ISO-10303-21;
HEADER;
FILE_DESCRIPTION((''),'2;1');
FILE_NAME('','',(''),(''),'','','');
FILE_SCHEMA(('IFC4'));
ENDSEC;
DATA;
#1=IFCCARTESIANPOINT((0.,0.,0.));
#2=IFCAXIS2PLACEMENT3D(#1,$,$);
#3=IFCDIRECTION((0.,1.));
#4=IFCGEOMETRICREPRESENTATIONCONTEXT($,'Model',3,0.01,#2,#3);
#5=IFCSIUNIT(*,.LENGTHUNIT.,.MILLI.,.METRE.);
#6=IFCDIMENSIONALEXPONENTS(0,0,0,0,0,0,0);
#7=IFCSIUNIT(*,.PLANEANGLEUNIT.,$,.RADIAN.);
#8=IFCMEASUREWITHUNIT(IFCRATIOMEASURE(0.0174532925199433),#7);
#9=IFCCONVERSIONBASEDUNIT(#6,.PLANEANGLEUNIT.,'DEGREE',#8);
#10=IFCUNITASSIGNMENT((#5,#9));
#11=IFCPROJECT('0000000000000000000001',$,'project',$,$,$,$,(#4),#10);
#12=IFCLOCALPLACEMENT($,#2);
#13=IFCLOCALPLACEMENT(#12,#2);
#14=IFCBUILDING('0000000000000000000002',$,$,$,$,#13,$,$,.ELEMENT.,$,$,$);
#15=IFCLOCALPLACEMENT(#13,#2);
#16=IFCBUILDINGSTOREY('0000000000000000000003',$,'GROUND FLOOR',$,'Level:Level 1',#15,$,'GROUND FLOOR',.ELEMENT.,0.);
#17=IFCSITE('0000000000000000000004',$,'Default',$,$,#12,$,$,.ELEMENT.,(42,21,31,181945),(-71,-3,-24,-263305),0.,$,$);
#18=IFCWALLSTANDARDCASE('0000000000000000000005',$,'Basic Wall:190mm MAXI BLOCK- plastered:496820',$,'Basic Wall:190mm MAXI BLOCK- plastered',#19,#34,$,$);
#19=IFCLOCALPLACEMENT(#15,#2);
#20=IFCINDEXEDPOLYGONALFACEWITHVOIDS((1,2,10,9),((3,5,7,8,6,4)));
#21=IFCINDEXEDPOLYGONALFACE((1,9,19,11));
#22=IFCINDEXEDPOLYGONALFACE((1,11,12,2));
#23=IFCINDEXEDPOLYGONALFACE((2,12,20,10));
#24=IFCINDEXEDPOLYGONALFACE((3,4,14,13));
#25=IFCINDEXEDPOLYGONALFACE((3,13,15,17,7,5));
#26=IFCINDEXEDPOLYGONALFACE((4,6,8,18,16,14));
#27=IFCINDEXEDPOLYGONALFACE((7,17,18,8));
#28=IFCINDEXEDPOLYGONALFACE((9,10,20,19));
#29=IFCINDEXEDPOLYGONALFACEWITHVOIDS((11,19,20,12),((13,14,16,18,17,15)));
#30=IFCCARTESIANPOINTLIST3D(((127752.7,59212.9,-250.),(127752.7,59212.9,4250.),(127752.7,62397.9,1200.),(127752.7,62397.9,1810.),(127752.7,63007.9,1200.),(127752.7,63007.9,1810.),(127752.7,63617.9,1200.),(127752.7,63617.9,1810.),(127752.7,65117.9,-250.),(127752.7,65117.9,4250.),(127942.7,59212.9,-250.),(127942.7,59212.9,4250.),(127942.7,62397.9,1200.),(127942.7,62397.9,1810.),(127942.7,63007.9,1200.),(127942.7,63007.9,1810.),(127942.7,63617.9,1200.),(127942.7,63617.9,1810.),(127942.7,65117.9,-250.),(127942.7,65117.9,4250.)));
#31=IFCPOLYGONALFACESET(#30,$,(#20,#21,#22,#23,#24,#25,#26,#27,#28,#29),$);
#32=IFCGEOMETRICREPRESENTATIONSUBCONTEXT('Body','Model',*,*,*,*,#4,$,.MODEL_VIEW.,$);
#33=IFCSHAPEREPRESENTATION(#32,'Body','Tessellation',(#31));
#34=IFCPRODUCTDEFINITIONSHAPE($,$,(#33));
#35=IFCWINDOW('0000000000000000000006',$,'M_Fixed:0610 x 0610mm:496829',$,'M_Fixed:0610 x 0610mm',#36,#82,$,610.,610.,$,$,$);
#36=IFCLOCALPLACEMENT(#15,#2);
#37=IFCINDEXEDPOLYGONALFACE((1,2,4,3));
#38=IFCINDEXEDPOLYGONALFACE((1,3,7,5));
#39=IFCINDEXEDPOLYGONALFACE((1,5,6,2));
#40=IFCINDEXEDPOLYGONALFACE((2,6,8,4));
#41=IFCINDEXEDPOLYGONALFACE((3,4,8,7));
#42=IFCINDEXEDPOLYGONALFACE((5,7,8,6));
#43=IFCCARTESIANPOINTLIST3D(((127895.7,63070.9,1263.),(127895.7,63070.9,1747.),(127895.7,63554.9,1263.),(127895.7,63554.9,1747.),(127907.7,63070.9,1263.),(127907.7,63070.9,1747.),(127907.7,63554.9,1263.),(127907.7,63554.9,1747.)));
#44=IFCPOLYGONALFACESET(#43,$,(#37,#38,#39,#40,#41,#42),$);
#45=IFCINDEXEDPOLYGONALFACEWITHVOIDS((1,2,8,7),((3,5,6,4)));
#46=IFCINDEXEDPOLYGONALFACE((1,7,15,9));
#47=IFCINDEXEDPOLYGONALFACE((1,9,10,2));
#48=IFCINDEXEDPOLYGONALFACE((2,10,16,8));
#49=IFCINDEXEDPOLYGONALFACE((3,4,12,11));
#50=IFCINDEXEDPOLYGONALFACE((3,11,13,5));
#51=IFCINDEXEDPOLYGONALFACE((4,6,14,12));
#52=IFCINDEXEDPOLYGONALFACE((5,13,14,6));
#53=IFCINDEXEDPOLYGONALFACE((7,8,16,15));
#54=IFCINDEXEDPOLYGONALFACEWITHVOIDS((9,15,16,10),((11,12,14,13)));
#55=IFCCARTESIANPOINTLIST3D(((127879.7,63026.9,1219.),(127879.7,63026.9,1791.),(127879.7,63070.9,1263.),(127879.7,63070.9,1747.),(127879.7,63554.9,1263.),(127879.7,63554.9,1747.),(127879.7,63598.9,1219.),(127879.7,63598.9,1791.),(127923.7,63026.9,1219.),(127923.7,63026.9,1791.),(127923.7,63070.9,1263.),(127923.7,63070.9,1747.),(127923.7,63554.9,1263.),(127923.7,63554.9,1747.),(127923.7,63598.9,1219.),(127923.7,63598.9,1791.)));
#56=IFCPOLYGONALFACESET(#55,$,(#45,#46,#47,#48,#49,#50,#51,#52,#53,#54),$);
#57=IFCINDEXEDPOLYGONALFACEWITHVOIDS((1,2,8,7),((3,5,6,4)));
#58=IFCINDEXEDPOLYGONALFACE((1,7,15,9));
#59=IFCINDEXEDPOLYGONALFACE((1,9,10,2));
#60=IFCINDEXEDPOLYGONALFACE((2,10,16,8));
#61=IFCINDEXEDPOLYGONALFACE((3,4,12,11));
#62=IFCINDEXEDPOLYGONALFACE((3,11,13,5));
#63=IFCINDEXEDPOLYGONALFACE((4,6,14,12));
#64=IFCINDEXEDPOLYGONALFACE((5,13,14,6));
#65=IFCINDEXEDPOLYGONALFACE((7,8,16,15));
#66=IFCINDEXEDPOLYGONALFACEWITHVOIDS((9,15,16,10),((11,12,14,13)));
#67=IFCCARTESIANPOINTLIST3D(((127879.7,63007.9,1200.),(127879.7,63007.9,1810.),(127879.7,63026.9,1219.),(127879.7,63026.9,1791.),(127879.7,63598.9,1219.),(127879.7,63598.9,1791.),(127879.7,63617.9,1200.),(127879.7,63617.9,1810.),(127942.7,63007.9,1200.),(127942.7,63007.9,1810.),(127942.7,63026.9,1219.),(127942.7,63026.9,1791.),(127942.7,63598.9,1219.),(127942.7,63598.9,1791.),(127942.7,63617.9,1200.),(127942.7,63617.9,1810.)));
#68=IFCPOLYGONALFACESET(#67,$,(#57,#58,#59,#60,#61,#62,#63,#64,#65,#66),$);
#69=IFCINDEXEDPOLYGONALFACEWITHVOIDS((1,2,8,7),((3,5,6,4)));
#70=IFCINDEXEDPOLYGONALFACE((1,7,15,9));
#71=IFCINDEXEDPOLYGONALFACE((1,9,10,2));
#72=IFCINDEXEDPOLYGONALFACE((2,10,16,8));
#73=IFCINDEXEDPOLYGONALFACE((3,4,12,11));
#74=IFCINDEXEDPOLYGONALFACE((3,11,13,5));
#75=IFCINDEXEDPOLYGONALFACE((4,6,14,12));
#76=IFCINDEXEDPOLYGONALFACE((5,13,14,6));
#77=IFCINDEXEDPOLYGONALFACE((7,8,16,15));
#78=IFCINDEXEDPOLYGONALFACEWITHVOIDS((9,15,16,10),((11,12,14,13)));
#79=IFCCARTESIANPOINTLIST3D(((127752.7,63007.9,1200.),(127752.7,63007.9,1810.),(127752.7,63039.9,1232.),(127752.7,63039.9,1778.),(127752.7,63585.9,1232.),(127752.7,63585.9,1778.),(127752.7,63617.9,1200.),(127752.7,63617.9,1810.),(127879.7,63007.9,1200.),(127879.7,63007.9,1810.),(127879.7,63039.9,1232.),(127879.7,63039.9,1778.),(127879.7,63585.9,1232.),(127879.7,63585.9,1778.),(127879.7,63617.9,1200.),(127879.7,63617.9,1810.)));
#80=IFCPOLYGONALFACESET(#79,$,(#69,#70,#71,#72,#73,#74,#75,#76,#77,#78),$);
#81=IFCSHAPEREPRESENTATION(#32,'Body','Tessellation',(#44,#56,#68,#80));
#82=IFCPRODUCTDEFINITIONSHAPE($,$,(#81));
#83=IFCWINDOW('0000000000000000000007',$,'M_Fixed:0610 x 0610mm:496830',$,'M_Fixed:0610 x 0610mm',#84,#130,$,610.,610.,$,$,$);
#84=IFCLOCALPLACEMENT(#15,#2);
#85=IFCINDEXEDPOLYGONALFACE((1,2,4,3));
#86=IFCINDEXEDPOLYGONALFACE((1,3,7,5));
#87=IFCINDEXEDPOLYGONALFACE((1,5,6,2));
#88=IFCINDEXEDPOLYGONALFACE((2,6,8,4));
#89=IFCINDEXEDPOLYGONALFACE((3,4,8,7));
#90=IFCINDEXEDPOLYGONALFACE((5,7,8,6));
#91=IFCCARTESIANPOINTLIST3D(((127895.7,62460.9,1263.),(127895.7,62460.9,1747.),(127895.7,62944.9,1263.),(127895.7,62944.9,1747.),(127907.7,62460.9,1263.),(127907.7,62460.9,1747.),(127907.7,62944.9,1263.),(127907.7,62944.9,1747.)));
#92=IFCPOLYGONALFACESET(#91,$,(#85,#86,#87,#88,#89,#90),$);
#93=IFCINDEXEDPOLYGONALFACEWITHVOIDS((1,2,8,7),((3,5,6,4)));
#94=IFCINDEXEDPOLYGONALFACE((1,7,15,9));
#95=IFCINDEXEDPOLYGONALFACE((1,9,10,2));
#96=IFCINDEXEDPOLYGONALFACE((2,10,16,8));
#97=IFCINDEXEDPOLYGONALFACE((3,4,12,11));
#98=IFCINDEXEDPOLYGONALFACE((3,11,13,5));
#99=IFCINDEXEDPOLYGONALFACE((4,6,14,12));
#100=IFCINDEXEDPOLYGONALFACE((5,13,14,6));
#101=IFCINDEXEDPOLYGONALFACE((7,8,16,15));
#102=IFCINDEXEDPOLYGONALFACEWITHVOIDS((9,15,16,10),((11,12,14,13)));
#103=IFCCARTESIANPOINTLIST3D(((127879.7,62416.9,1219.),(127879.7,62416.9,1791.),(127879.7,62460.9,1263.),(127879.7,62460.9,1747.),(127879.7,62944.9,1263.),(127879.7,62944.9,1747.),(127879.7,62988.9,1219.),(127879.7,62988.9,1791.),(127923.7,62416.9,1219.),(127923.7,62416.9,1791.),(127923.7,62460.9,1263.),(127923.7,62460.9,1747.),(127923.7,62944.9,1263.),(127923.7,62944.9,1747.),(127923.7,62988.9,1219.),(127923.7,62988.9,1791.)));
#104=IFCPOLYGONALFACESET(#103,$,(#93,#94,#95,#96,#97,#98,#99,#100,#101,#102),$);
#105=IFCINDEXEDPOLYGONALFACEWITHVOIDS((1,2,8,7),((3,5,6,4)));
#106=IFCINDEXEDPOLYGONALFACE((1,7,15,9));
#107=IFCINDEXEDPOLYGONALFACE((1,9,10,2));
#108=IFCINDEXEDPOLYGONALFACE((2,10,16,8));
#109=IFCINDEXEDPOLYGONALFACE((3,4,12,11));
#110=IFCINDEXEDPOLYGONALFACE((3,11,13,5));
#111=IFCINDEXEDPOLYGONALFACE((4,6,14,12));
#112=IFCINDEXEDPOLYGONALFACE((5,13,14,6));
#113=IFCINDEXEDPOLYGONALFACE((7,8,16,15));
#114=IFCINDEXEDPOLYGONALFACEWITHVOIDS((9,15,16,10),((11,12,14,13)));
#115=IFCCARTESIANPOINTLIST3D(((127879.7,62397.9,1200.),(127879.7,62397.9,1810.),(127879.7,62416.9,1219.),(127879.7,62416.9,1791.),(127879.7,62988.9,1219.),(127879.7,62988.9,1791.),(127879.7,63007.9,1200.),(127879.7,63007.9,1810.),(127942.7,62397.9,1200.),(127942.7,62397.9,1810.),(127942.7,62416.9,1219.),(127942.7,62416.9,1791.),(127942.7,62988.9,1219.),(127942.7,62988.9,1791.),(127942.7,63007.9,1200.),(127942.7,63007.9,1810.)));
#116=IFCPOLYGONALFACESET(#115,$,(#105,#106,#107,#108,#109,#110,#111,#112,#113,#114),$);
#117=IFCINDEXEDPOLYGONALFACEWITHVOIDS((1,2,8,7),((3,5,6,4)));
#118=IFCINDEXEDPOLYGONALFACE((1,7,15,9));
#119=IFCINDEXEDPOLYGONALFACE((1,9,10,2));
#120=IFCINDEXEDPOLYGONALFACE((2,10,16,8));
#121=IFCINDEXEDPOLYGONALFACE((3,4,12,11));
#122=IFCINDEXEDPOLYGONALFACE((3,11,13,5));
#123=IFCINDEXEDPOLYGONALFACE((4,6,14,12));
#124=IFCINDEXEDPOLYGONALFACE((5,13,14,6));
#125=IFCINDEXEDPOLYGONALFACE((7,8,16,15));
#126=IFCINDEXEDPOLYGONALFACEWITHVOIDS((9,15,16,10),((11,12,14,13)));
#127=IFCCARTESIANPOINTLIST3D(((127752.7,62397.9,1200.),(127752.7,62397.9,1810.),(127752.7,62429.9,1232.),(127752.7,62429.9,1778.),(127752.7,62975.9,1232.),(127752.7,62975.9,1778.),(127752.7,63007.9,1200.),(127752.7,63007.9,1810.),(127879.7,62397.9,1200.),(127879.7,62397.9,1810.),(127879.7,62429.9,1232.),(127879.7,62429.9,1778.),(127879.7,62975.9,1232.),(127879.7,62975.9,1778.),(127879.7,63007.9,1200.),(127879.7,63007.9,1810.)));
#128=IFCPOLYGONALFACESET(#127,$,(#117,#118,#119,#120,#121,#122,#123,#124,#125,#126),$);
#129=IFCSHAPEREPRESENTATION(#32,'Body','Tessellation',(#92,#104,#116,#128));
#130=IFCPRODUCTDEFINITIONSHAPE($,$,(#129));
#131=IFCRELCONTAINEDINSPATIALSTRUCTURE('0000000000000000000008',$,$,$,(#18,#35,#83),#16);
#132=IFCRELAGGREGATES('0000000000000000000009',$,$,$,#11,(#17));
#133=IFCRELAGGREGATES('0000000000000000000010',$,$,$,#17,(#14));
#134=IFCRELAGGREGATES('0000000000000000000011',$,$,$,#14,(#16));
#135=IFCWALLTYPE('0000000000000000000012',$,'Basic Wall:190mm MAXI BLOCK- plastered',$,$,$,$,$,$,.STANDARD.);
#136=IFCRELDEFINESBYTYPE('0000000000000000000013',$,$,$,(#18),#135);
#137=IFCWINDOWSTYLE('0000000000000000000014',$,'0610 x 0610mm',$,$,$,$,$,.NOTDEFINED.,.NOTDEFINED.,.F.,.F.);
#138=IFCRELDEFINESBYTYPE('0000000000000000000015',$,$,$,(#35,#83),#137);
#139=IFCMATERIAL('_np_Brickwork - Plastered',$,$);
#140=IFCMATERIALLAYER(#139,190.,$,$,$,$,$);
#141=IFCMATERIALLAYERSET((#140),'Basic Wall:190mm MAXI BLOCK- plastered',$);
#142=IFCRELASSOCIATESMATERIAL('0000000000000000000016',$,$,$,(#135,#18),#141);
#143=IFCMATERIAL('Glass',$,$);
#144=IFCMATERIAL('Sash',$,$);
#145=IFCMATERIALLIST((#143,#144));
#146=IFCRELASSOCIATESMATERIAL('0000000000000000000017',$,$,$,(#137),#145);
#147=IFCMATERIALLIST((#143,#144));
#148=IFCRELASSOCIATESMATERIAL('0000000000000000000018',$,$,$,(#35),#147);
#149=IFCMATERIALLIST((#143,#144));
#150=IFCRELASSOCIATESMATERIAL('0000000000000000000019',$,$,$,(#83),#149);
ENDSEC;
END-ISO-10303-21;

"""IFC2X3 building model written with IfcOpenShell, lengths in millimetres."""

from ifc_helpers import new_model, entity, si_unit, converted_unit, direction, frame, frame_2d, origin, place, context, subcontext, project, spatial, polyline, rectangle, outline, extrude, source, transform, mapped, material, material_list, layer, layer_set, layer_usage, type_object, type_shapes, element, fill, save


model = new_model("IFC2X3")

# Units and contexts
model_context = context("Model", 3, precision=0.01, world=origin(), true_north=direction((0.0, 1.0)))
body_context = subcontext(model_context, "Body", "Model", "MODEL_VIEW")
ifc_project = project(units=[si_unit("LENGTHUNIT", "METRE", prefix="MILLI"), converted_unit("PLANEANGLEUNIT", "DEGREE", entity("IfcRatioMeasure", 0.0174532925199433), si_unit("PLANEANGLEUNIT", "RADIAN"), dimensions=[0, 0, 0, 0, 0, 0, 0])], contexts=[model_context])

# Site, building, storey
site_placement = place(None, origin())
site = spatial("IfcSite", under=ifc_project, at=site_placement, Name="Default", CompositionType="ELEMENT", RefLatitude=(42, 21, 31, 181945), RefLongitude=(-71, -3, -24, -263305), RefElevation=0.0)
building_placement = place(site_placement, origin())
building = spatial("IfcBuilding", under=site, at=building_placement, CompositionType="ELEMENT")
storey_placement = place(building_placement, origin())
storey = spatial("IfcBuildingStorey", under=building, at=storey_placement, Name="GROUND FLOOR", ObjectType="Level:Level 1", LongName="GROUND FLOOR", CompositionType="ELEMENT", Elevation=0.0)

# Wall, openings, windows
ifc_material_1 = material(Name="_np_Brickwork - Plastered")
ifc_layer = layer(ifc_material_1, 190.0)
ifc_layer_set = layer_set([ifc_layer], Name="Basic Wall:190mm MAXI BLOCK- plastered")
wall_type = type_object("IfcWallType", Name="Basic Wall:190mm MAXI BLOCK- plastered", PredefinedType="STANDARD", material=ifc_layer_set)
ifc_material_2 = material(Name="Glass")
ifc_material_3 = material(Name="Sash")
ifc_material_list_1 = material_list([ifc_material_2, ifc_material_3])
window_style = type_object("IfcWindowStyle", Name="0610 x 0610mm", ConstructionType="NOTDEFINED", OperationType="NOTDEFINED", ParameterTakesPrecedence=False, Sizeable=False, material=ifc_material_list_1)
shared_shape = source(origin(), body_context, "Body", "SweptSolid", [
    extrude(rectangle(XDim=12.0, YDim=484.0, at=frame_2d((0.0, 0.0), x_axis=(1.0, 0.0))), frame((305.0, 149.0, 63.0), z_axis=(0.0, 0.0, 1.0), x_axis=(0.0, -1.0, 0.0)), (0.0, 0.0, 1.0), 484.0),
    extrude(outline(polyline([(-286.0, -286.0), (286.0, -286.0), (286.0, 286.0), (-286.0, 286.0), (-286.0, -286.0)]), holes=[polyline([(-242.0, -242.0), (-242.0, 242.0), (242.0, 242.0), (242.0, -242.0), (-242.0, -242.0)])]), frame((305.0, 127.0, 305.0), z_axis=(0.0, 1.0, 0.0), x_axis=(1.0, 0.0, 0.0)), (0.0, 0.0, 1.0), 44.0),
    extrude(outline(polyline([(-305.0, -305.0), (305.0, -305.0), (305.0, 305.0), (-305.0, 305.0), (-305.0, -305.0)]), holes=[polyline([(-286.0, -286.0), (-286.0, 286.0), (286.0, 286.0), (286.0, -286.0), (-286.0, -286.0)])]), frame((305.0, 127.0, 305.0), z_axis=(0.0, 1.0, 0.0), x_axis=(1.0, 0.0, 0.0)), (0.0, 0.0, 1.0), 63.0),
    extrude(outline(polyline([(-305.0, -305.0), (305.0, -305.0), (305.0, 305.0), (-305.0, 305.0), (-305.0, -305.0)]), holes=[polyline([(-273.0, -273.0), (-273.0, 273.0), (273.0, 273.0), (273.0, -273.0), (-273.0, -273.0)])]), frame((305.0, 0.0, 305.0), z_axis=(0.0, 1.0, 0.0), x_axis=(1.0, 0.0, 0.0)), (0.0, 0.0, 1.0), 127.0),
])
type_shapes(window_style, [shared_shape])
ifc_layer_usage_1 = layer_usage(ifc_layer_set, "AXIS2", "NEGATIVE", 95.0)
wall_1_placement = place(storey_placement, frame((127847.7, 59212.9, -250.0), z_axis=(0.0, 0.0, 1.0), x_axis=(0.0, 1.0, 0.0)))
wall_1 = element("IfcWallStandardCase", 1, at=wall_1_placement, inside=storey, type_object=wall_type, material=ifc_layer_usage_1, Name="Basic Wall:190mm MAXI BLOCK- plastered:496820", ObjectType="Basic Wall:190mm MAXI BLOCK- plastered", context=body_context, shape_type="SweptSolid", body=[
    extrude(rectangle(XDim=5905.0, YDim=190.0, at=frame_2d((2952.5, 0.0), x_axis=(-1.0, 0.0))), origin(), (0.0, 0.0, 1.0), 4500.0),
])
opening_1_placement = place(wall_1_placement, frame((4405.0, 95.0, 1450.0)))
opening_1 = element("IfcOpeningElement", 2, at=opening_1_placement, cuts=wall_1, ObjectType="Opening", context=body_context, shape_type="SweptSolid", body=[
    extrude(rectangle(XDim=610.0, YDim=610.0, at=frame_2d((305.0, 305.0), x_axis=(1.0, 0.0))), frame((0.0, 0.0, 0.0), z_axis=(0.0, -1.0, 0.0), x_axis=(0.0, 0.0, 1.0)), (0.0, 0.0, 1.0), 190.0),
])
opening_2_placement = place(wall_1_placement, frame((3795.0, 95.0, 1450.0)))
opening_2 = element("IfcOpeningElement", 3, at=opening_2_placement, cuts=wall_1, ObjectType="Opening", context=body_context, shape_type="SweptSolid", body=[
    extrude(rectangle(XDim=610.0, YDim=610.0, at=frame_2d((305.0, 305.0), x_axis=(1.0, 0.0))), frame((0.0, 0.0, 0.0), z_axis=(0.0, -1.0, 0.0), x_axis=(0.0, 0.0, 1.0)), (0.0, 0.0, 1.0), 190.0),
])
ifc_material_list_2 = material_list([ifc_material_2, ifc_material_3])
window_1_placement = place(opening_1_placement, frame((0.0, 0.0, 0.0), z_axis=(0.0, 0.0, 1.0), x_axis=(-1.0, 0.0, 0.0)))
window_1 = element("IfcWindow", 4, at=window_1_placement, inside=storey, type_object=window_style, material=ifc_material_list_2, Name="M_Fixed:0610 x 0610mm:496829", ObjectType="M_Fixed:0610 x 0610mm", OverallHeight=610.0, OverallWidth=610.0, context=body_context, shape_type="MappedRepresentation", body=[
    mapped(shared_shape, transform((0.0, 0.0, 0.0), scale=1.0)),
])
fill(opening_1, window_1)
ifc_material_list_3 = material_list([ifc_material_2, ifc_material_3])
window_2_placement = place(opening_2_placement, frame((0.0, 0.0, 0.0), z_axis=(0.0, 0.0, 1.0), x_axis=(-1.0, 0.0, 0.0)))
window_2 = element("IfcWindow", 5, at=window_2_placement, inside=storey, type_object=window_style, material=ifc_material_list_3, Name="M_Fixed:0610 x 0610mm:496830", ObjectType="M_Fixed:0610 x 0610mm", OverallHeight=610.0, OverallWidth=610.0, context=body_context, shape_type="MappedRepresentation", body=[
    mapped(shared_shape, transform((0.0, 0.0, 0.0), scale=1.0)),
])
fill(opening_2, window_2)

save(model, "model.ifc")
